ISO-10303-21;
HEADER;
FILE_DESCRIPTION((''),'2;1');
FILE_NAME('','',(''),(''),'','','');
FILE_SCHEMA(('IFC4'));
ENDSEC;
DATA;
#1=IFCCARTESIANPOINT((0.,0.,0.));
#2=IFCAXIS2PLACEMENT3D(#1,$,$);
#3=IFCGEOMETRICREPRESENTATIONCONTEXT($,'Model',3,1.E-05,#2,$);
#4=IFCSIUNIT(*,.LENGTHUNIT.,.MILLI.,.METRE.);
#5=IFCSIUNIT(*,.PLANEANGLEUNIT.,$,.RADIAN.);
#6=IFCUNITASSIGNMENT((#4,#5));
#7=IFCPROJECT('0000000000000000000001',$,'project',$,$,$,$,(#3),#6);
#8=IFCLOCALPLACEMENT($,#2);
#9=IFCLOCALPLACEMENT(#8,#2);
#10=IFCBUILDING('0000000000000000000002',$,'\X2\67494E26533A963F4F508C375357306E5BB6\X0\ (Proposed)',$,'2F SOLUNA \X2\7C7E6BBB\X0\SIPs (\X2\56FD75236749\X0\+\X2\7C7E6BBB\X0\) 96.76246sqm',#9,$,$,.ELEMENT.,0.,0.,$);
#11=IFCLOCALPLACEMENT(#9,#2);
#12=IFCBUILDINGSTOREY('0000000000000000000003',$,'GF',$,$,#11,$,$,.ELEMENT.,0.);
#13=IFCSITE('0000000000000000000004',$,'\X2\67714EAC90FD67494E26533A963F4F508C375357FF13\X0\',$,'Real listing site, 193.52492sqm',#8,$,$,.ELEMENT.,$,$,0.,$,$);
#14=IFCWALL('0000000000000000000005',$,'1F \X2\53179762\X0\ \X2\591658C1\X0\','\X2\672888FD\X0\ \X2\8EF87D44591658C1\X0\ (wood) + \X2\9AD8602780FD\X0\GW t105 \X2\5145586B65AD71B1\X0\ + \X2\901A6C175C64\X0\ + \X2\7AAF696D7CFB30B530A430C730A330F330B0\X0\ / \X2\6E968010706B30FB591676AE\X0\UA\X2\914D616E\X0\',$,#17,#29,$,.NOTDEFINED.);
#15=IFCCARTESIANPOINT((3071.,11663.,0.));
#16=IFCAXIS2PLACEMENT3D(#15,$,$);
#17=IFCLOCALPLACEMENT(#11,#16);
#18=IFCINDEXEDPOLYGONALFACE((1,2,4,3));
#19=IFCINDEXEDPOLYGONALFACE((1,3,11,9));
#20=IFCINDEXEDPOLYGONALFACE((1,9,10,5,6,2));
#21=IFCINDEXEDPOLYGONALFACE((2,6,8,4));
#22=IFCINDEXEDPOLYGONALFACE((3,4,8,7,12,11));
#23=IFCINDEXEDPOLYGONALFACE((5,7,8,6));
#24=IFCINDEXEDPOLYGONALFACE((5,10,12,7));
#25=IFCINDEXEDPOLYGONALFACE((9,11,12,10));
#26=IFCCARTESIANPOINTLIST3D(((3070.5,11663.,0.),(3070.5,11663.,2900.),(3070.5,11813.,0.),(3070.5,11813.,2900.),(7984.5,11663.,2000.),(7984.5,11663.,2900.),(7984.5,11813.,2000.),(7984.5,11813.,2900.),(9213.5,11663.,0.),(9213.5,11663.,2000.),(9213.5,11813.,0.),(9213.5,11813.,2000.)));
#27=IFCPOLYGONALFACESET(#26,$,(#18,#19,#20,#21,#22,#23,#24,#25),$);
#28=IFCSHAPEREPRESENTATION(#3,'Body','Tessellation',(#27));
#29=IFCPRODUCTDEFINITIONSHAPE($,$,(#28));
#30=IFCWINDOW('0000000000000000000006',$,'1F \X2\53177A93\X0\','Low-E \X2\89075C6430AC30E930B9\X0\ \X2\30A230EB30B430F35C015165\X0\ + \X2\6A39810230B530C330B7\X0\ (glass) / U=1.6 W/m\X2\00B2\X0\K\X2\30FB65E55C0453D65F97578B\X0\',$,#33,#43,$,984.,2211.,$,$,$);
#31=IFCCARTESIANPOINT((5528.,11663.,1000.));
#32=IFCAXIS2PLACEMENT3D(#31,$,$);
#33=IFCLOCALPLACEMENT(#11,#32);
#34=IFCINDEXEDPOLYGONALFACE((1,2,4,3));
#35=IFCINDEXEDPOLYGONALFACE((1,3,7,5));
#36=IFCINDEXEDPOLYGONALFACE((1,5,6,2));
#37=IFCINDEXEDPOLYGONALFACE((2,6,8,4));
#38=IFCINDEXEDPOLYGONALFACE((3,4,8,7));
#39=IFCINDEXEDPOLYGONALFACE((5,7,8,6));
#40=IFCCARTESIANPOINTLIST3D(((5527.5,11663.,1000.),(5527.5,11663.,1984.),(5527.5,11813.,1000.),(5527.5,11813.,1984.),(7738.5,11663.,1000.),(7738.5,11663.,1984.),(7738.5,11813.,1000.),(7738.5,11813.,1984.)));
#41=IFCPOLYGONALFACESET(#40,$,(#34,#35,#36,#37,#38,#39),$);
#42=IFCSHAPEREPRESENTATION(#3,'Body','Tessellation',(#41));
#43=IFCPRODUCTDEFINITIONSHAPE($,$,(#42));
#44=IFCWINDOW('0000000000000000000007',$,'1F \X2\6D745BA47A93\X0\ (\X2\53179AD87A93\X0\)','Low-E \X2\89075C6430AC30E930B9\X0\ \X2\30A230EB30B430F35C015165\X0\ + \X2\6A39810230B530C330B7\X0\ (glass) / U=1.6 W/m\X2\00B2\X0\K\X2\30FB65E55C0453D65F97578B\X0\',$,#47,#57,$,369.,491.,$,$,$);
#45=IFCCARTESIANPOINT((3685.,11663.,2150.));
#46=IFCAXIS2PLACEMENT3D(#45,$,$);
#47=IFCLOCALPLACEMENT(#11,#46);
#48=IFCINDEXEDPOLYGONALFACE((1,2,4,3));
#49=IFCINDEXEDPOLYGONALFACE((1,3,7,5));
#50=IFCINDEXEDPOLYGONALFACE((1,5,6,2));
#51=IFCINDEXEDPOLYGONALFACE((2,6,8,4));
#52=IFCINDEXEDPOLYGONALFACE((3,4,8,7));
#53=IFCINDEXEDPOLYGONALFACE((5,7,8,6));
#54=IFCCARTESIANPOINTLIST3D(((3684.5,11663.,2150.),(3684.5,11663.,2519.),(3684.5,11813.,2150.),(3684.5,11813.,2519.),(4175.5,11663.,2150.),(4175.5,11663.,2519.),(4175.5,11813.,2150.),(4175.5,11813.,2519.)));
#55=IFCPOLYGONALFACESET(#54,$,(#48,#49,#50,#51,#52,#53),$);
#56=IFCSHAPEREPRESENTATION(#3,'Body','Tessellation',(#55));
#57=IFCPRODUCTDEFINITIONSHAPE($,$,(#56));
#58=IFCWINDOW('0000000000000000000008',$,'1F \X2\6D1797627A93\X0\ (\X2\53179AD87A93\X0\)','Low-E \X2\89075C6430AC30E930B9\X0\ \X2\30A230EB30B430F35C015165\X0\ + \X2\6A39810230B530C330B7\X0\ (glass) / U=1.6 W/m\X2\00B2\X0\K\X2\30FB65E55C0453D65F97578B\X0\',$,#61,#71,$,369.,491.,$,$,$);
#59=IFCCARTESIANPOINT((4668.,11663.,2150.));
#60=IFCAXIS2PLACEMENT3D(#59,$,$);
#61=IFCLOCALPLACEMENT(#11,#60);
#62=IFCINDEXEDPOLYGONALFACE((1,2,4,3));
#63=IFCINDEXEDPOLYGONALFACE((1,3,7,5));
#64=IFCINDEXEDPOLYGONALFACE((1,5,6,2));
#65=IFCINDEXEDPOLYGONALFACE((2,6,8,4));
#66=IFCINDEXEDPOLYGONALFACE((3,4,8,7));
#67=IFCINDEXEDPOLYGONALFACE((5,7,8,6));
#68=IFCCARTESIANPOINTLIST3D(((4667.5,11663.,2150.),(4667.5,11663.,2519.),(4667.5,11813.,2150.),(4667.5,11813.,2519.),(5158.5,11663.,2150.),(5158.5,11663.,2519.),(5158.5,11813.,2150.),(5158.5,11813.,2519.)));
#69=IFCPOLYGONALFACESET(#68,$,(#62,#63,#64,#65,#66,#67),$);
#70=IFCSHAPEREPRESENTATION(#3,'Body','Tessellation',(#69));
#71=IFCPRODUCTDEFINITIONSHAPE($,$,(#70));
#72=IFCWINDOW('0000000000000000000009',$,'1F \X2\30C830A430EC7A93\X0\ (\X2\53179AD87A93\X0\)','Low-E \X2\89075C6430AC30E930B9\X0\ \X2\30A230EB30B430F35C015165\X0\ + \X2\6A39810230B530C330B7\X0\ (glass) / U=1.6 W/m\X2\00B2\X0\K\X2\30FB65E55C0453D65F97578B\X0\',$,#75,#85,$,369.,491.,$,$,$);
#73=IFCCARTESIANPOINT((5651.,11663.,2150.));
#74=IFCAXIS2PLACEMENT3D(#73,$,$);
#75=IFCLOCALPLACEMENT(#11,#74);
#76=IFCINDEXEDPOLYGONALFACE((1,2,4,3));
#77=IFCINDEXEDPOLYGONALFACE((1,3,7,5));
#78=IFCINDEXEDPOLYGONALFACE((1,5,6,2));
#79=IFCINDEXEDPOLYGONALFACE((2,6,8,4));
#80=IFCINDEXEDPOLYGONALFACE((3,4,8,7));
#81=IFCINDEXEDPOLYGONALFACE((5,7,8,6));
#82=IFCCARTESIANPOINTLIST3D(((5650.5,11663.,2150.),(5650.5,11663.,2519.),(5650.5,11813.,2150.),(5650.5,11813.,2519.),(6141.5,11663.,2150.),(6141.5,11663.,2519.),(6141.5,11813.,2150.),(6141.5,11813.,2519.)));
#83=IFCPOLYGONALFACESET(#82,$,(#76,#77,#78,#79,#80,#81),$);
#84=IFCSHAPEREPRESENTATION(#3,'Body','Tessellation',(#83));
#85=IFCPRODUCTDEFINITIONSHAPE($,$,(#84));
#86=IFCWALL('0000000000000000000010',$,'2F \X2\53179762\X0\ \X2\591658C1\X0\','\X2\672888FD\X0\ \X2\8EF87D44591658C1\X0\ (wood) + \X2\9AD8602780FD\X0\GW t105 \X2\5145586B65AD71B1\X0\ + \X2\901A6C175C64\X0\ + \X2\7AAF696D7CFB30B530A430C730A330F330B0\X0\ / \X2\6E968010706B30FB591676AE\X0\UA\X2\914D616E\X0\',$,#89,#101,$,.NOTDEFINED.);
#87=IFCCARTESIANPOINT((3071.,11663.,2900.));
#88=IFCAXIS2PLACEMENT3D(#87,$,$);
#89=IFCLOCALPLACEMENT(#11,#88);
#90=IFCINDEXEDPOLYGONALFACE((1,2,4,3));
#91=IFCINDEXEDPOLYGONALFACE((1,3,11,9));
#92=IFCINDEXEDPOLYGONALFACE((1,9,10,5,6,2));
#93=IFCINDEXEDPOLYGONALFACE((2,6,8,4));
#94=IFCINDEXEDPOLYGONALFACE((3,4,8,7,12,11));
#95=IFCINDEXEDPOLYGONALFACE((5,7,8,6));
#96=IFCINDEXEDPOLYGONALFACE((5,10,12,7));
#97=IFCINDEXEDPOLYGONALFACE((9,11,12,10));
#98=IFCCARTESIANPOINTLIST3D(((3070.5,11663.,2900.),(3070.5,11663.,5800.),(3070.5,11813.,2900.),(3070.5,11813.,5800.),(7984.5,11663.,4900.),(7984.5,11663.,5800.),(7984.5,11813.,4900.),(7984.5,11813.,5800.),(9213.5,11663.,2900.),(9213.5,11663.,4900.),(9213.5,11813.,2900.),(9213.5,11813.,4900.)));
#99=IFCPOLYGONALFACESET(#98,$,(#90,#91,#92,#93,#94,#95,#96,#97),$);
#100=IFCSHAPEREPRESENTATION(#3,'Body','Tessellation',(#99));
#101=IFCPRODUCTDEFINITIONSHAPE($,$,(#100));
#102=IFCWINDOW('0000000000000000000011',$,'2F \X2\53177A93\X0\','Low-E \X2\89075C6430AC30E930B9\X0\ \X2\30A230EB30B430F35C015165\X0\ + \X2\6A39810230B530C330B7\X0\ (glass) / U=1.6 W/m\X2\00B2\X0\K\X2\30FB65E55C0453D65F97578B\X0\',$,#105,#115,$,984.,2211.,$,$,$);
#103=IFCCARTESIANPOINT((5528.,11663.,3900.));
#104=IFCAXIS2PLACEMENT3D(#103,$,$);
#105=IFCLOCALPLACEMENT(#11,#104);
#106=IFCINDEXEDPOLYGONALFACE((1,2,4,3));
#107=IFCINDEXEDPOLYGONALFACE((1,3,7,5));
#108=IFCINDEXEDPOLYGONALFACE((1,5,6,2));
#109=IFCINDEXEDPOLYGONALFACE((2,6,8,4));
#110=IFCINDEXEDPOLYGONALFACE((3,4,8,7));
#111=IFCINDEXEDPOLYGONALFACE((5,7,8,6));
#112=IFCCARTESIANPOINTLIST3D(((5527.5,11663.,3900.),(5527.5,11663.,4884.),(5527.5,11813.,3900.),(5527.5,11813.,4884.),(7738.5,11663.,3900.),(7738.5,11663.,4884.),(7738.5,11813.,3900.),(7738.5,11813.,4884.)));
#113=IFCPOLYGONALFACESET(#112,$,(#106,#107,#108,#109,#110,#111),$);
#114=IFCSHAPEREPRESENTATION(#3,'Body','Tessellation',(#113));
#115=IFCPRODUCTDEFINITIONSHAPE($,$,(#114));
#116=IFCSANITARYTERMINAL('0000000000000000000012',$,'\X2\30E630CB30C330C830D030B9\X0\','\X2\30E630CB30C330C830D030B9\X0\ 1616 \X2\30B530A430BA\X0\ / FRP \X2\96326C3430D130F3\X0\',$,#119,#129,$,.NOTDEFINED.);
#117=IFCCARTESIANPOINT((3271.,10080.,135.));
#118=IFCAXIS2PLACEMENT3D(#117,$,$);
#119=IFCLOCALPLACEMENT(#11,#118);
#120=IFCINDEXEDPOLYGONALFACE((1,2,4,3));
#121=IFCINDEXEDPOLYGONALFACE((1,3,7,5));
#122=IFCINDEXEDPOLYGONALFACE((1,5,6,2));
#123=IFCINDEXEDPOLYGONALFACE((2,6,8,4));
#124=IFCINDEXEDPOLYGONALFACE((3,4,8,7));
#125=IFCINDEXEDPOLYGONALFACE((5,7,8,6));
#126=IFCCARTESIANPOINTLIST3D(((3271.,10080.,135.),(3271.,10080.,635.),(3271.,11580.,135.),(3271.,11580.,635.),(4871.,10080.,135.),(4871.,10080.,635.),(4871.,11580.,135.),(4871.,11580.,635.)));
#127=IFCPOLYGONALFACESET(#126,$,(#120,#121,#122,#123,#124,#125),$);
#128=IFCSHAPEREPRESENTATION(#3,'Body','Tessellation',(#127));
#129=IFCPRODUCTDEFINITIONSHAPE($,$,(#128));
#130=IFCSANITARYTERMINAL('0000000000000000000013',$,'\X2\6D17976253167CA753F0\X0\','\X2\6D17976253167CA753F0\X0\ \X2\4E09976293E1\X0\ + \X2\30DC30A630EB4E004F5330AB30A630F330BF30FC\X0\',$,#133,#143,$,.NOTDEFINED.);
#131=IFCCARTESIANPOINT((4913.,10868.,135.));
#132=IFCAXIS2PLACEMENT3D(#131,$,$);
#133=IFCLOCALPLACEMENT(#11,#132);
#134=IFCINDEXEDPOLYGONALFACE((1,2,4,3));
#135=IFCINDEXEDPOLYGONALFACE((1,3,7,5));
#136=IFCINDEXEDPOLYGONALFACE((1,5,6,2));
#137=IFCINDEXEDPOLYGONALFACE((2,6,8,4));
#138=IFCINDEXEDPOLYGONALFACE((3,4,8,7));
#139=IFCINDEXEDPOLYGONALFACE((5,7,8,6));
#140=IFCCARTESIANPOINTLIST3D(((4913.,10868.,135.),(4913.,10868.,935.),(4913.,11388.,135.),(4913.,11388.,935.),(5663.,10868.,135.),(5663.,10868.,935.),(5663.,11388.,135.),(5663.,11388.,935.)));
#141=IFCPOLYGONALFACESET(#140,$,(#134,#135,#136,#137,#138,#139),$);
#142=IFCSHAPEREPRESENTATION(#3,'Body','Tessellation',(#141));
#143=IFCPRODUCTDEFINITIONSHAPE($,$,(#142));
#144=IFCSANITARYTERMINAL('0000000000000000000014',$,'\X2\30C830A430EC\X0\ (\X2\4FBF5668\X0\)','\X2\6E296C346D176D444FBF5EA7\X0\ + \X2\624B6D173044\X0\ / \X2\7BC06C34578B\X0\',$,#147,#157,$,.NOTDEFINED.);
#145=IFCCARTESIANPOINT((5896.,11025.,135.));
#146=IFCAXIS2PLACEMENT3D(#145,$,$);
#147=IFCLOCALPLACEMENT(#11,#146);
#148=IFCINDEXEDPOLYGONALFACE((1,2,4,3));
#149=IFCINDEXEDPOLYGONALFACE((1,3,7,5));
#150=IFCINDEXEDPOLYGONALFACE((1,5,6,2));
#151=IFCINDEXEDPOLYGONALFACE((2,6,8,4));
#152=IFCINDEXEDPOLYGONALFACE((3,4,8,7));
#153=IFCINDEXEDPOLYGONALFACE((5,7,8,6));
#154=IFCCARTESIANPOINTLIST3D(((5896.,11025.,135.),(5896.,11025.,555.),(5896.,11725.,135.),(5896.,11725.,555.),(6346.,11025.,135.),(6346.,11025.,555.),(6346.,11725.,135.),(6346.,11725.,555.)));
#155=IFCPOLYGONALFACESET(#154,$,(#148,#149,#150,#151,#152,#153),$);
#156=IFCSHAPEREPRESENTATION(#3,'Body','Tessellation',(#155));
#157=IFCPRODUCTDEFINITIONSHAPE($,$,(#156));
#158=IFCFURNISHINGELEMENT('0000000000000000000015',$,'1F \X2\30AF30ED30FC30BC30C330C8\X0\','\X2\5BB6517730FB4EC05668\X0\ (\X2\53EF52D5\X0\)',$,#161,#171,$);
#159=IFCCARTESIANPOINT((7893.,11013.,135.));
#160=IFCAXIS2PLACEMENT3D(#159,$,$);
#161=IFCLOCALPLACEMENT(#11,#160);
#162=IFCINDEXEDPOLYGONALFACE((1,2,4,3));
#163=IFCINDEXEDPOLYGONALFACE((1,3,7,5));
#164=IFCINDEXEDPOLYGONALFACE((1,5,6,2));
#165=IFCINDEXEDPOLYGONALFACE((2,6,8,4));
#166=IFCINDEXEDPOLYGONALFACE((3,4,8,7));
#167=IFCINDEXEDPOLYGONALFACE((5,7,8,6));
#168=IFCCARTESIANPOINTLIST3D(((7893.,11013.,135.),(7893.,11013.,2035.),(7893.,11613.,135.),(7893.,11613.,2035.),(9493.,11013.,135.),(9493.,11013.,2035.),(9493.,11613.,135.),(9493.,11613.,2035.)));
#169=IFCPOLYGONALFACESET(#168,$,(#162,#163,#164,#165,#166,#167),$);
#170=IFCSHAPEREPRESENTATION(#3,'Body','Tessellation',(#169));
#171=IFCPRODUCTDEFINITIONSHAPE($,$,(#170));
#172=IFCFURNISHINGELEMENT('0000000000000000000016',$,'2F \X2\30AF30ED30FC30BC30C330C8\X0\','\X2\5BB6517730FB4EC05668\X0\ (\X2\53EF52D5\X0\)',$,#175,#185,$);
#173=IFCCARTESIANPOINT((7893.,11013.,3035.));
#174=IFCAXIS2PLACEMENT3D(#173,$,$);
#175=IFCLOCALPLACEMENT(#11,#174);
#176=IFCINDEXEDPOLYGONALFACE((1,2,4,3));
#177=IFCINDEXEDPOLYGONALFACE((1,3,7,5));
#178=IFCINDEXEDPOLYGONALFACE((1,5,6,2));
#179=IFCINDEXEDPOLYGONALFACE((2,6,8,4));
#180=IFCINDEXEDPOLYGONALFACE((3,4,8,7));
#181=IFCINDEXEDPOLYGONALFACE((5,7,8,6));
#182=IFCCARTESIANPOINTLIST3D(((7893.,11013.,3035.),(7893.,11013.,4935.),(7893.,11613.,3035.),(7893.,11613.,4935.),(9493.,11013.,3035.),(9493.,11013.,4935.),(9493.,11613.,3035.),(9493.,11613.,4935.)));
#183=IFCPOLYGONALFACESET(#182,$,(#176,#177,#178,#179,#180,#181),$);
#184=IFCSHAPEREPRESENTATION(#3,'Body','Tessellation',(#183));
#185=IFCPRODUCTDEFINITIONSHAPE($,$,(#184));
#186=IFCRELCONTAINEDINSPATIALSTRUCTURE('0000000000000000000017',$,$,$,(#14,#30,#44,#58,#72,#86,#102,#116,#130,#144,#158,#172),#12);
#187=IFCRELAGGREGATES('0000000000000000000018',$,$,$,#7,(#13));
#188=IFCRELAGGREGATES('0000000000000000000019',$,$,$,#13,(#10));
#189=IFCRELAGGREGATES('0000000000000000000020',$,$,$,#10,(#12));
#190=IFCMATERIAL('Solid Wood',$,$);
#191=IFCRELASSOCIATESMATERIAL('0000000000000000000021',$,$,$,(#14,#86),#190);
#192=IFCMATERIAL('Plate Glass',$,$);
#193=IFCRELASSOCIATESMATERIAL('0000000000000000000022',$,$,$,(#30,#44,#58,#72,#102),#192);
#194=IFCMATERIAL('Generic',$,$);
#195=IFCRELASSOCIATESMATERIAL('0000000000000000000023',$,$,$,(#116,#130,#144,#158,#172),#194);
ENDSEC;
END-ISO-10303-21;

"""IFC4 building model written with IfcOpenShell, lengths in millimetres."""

from ifc_helpers import new_model, si_unit, frame, frame_2d, origin, place, context, project, spatial, rectangle, extrude, material, element, fill, save


model = new_model("IFC4")

# Units and contexts
model_context = context("Model", 3, precision=1e-05, world=origin())
ifc_project = project(units=[si_unit("LENGTHUNIT", "METRE", prefix="MILLI"), si_unit("PLANEANGLEUNIT", "RADIAN")], contexts=[model_context])

# Site, building, storey
site_placement = place(None, origin())
site = spatial("IfcSite", under=ifc_project, at=site_placement, Name="東京都杉並区阿佐谷南３", ObjectType="Real listing site, 193.52492sqm", CompositionType="ELEMENT", RefElevation=0.0)
building_placement = place(site_placement, origin())
building = spatial("IfcBuilding", under=site, at=building_placement, Name="杉並区阿佐谷南の家 (Proposed)", ObjectType="2F SOLUNA 籾殻SIPs (国産杉+籾殻) 96.76246sqm", CompositionType="ELEMENT", ElevationOfRefHeight=0.0, ElevationOfTerrain=0.0)
storey_placement = place(building_placement, origin())
storey = spatial("IfcBuildingStorey", under=building, at=storey_placement, Name="GF", CompositionType="ELEMENT", Elevation=0.0)

# Wall, openings, windows
ifc_material_1 = material(Name="Solid Wood")
wall_1_placement = place(storey_placement, frame((3071.0, 11663.0, 0.0)))
wall_1 = element("IfcWall", 1, at=wall_1_placement, inside=storey, material=ifc_material_1, Name="1F 北面 外壁", Description="木製 軸組外壁 (wood) + 高性能GW t105 充填断熱 + 通気層 + 窯業系サイディング / 準耐火・外皮UA配慮", PredefinedType="NOTDEFINED", context=model_context, shape_type="SweptSolid", body=[
    extrude(rectangle(XDim=6143.0, YDim=150.0, at=frame_2d((3071.0, 75.0))), frame((3071.0, 11663.0, 0.0)), (0.0, 0.0, 1.0), 2900.0),
])
opening_1_placement = place(storey_placement, frame((5528.0, 11663.0, 1000.0)))
opening_1 = element("IfcOpeningElement", 2, at=opening_1_placement, cuts=wall_1, PredefinedType="NOTDEFINED", context=model_context, shape_type="SweptSolid", body=[
    extrude(rectangle(XDim=2211.0, YDim=150.0, at=frame_2d((1105.0, 75.0))), frame((5528.0, 11663.0, 1000.0)), (0.0, 0.0, 1.0), 984.0),
])
opening_2_placement = place(storey_placement, frame((3685.0, 11663.0, 2150.0)))
opening_2 = element("IfcOpeningElement", 3, at=opening_2_placement, cuts=wall_1, PredefinedType="NOTDEFINED", context=model_context, shape_type="SweptSolid", body=[
    extrude(rectangle(XDim=491.0, YDim=150.0, at=frame_2d((245.0, 75.0))), frame((3685.0, 11663.0, 2150.0)), (0.0, 0.0, 1.0), 369.0),
])
opening_3_placement = place(storey_placement, frame((4668.0, 11663.0, 2150.0)))
opening_3 = element("IfcOpeningElement", 4, at=opening_3_placement, cuts=wall_1, PredefinedType="NOTDEFINED", context=model_context, shape_type="SweptSolid", body=[
    extrude(rectangle(XDim=491.0, YDim=150.0, at=frame_2d((245.0, 75.0))), frame((4668.0, 11663.0, 2150.0)), (0.0, 0.0, 1.0), 369.0),
])
opening_4_placement = place(storey_placement, frame((5651.0, 11663.0, 2150.0)))
opening_4 = element("IfcOpeningElement", 5, at=opening_4_placement, cuts=wall_1, PredefinedType="NOTDEFINED", context=model_context, shape_type="SweptSolid", body=[
    extrude(rectangle(XDim=491.0, YDim=150.0, at=frame_2d((245.0, 75.0))), frame((5651.0, 11663.0, 2150.0)), (0.0, 0.0, 1.0), 369.0),
])
ifc_material_2 = material(Name="Plate Glass")
window_1_placement = place(storey_placement, frame((5528.0, 11663.0, 1000.0)))
window_1 = element("IfcWindow", 6, at=window_1_placement, inside=storey, material=ifc_material_2, Name="1F 北窓", Description="Low-E 複層ガラス アルゴン封入 + 樹脂サッシ (glass) / U=1.6 W/m²K・日射取得型", OverallHeight=984.0, OverallWidth=2211.0, context=model_context, shape_type="SweptSolid", body=[
    extrude(rectangle(XDim=2211.0, YDim=150.0, at=frame_2d((1105.0, 75.0))), frame((5528.0, 11663.0, 1000.0)), (0.0, 0.0, 1.0), 984.0),
])
fill(opening_1, window_1)
window_2_placement = place(storey_placement, frame((3685.0, 11663.0, 2150.0)))
window_2 = element("IfcWindow", 7, at=window_2_placement, inside=storey, material=ifc_material_2, Name="1F 浴室窓 (北高窓)", Description="Low-E 複層ガラス アルゴン封入 + 樹脂サッシ (glass) / U=1.6 W/m²K・日射取得型", OverallHeight=369.0, OverallWidth=491.0, context=model_context, shape_type="SweptSolid", body=[
    extrude(rectangle(XDim=491.0, YDim=150.0, at=frame_2d((245.0, 75.0))), frame((3685.0, 11663.0, 2150.0)), (0.0, 0.0, 1.0), 369.0),
])
fill(opening_2, window_2)
window_3_placement = place(storey_placement, frame((4668.0, 11663.0, 2150.0)))
window_3 = element("IfcWindow", 8, at=window_3_placement, inside=storey, material=ifc_material_2, Name="1F 洗面窓 (北高窓)", Description="Low-E 複層ガラス アルゴン封入 + 樹脂サッシ (glass) / U=1.6 W/m²K・日射取得型", OverallHeight=369.0, OverallWidth=491.0, context=model_context, shape_type="SweptSolid", body=[
    extrude(rectangle(XDim=491.0, YDim=150.0, at=frame_2d((245.0, 75.0))), frame((4668.0, 11663.0, 2150.0)), (0.0, 0.0, 1.0), 369.0),
])
fill(opening_3, window_3)
window_4_placement = place(storey_placement, frame((5651.0, 11663.0, 2150.0)))
window_4 = element("IfcWindow", 9, at=window_4_placement, inside=storey, material=ifc_material_2, Name="1F トイレ窓 (北高窓)", Description="Low-E 複層ガラス アルゴン封入 + 樹脂サッシ (glass) / U=1.6 W/m²K・日射取得型", OverallHeight=369.0, OverallWidth=491.0, context=model_context, shape_type="SweptSolid", body=[
    extrude(rectangle(XDim=491.0, YDim=150.0, at=frame_2d((245.0, 75.0))), frame((5651.0, 11663.0, 2150.0)), (0.0, 0.0, 1.0), 369.0),
])
fill(opening_4, window_4)

# Wall, opening, window
wall_2_placement = place(storey_placement, frame((3071.0, 11663.0, 2900.0)))
wall_2 = element("IfcWall", 10, at=wall_2_placement, inside=storey, material=ifc_material_1, Name="2F 北面 外壁", Description="木製 軸組外壁 (wood) + 高性能GW t105 充填断熱 + 通気層 + 窯業系サイディング / 準耐火・外皮UA配慮", PredefinedType="NOTDEFINED", context=model_context, shape_type="SweptSolid", body=[
    extrude(rectangle(XDim=6143.0, YDim=150.0, at=frame_2d((3071.0, 75.0))), frame((3071.0, 11663.0, 2900.0)), (0.0, 0.0, 1.0), 2900.0),
])
opening_5_placement = place(storey_placement, frame((5528.0, 11663.0, 3900.0)))
opening_5 = element("IfcOpeningElement", 11, at=opening_5_placement, cuts=wall_2, PredefinedType="NOTDEFINED", context=model_context, shape_type="SweptSolid", body=[
    extrude(rectangle(XDim=2211.0, YDim=150.0, at=frame_2d((1105.0, 75.0))), frame((5528.0, 11663.0, 3900.0)), (0.0, 0.0, 1.0), 984.0),
])
window_5_placement = place(storey_placement, frame((5528.0, 11663.0, 3900.0)))
window_5 = element("IfcWindow", 12, at=window_5_placement, inside=storey, material=ifc_material_2, Name="2F 北窓", Description="Low-E 複層ガラス アルゴン封入 + 樹脂サッシ (glass) / U=1.6 W/m²K・日射取得型", OverallHeight=984.0, OverallWidth=2211.0, context=model_context, shape_type="SweptSolid", body=[
    extrude(rectangle(XDim=2211.0, YDim=150.0, at=frame_2d((1105.0, 75.0))), frame((5528.0, 11663.0, 3900.0)), (0.0, 0.0, 1.0), 984.0),
])
fill(opening_5, window_5)

# Sanitary terminals
ifc_material_3 = material(Name="Generic")
sanitary_terminal_1_placement = place(storey_placement, frame((3271.0, 10080.0, 135.0)))
element("IfcSanitaryTerminal", 13, at=sanitary_terminal_1_placement, inside=storey, material=ifc_material_3, Name="ユニットバス", Description="ユニットバス 1616 サイズ / FRP 防水パン", PredefinedType="NOTDEFINED", context=model_context, shape_type="SweptSolid", body=[
    extrude(rectangle(XDim=1600.0, YDim=1500.0, at=frame_2d((800.0, 750.0))), frame((3271.0, 10080.0, 135.0)), (0.0, 0.0, 1.0), 500.0),
])
sanitary_terminal_2_placement = place(storey_placement, frame((4913.0, 10868.0, 135.0)))
element("IfcSanitaryTerminal", 14, at=sanitary_terminal_2_placement, inside=storey, material=ifc_material_3, Name="洗面化粧台", Description="洗面化粧台 三面鏡 + ボウル一体カウンター", PredefinedType="NOTDEFINED", context=model_context, shape_type="SweptSolid", body=[
    extrude(rectangle(XDim=750.0, YDim=520.0, at=frame_2d((375.0, 260.0))), frame((4913.0, 10868.0, 135.0)), (0.0, 0.0, 1.0), 800.0),
])
sanitary_terminal_3_placement = place(storey_placement, frame((5896.0, 11025.0, 135.0)))
element("IfcSanitaryTerminal", 15, at=sanitary_terminal_3_placement, inside=storey, material=ifc_material_3, Name="トイレ (便器)", Description="温水洗浄便座 + 手洗い / 節水型", PredefinedType="NOTDEFINED", context=model_context, shape_type="SweptSolid", body=[
    extrude(rectangle(XDim=450.0, YDim=700.0, at=frame_2d((225.0, 350.0))), frame((5896.0, 11025.0, 135.0)), (0.0, 0.0, 1.0), 420.0),
])

# Furnishing elements
furnishing_1_placement = place(storey_placement, frame((7893.0, 11013.0, 135.0)))
element("IfcFurnishingElement", 16, at=furnishing_1_placement, inside=storey, material=ifc_material_3, Name="1F クローゼット", Description="家具・什器 (可動)", context=model_context, shape_type="SweptSolid", body=[
    extrude(rectangle(XDim=1600.0, YDim=600.0, at=frame_2d((800.0, 300.0))), frame((7893.0, 11013.0, 135.0)), (0.0, 0.0, 1.0), 1900.0),
])
furnishing_2_placement = place(storey_placement, frame((7893.0, 11013.0, 3035.0)))
element("IfcFurnishingElement", 17, at=furnishing_2_placement, inside=storey, material=ifc_material_3, Name="2F クローゼット", Description="家具・什器 (可動)", context=model_context, shape_type="SweptSolid", body=[
    extrude(rectangle(XDim=1600.0, YDim=600.0, at=frame_2d((800.0, 300.0))), frame((7893.0, 11013.0, 3035.0)), (0.0, 0.0, 1.0), 1900.0),
])

save(model, "model.ifc")
